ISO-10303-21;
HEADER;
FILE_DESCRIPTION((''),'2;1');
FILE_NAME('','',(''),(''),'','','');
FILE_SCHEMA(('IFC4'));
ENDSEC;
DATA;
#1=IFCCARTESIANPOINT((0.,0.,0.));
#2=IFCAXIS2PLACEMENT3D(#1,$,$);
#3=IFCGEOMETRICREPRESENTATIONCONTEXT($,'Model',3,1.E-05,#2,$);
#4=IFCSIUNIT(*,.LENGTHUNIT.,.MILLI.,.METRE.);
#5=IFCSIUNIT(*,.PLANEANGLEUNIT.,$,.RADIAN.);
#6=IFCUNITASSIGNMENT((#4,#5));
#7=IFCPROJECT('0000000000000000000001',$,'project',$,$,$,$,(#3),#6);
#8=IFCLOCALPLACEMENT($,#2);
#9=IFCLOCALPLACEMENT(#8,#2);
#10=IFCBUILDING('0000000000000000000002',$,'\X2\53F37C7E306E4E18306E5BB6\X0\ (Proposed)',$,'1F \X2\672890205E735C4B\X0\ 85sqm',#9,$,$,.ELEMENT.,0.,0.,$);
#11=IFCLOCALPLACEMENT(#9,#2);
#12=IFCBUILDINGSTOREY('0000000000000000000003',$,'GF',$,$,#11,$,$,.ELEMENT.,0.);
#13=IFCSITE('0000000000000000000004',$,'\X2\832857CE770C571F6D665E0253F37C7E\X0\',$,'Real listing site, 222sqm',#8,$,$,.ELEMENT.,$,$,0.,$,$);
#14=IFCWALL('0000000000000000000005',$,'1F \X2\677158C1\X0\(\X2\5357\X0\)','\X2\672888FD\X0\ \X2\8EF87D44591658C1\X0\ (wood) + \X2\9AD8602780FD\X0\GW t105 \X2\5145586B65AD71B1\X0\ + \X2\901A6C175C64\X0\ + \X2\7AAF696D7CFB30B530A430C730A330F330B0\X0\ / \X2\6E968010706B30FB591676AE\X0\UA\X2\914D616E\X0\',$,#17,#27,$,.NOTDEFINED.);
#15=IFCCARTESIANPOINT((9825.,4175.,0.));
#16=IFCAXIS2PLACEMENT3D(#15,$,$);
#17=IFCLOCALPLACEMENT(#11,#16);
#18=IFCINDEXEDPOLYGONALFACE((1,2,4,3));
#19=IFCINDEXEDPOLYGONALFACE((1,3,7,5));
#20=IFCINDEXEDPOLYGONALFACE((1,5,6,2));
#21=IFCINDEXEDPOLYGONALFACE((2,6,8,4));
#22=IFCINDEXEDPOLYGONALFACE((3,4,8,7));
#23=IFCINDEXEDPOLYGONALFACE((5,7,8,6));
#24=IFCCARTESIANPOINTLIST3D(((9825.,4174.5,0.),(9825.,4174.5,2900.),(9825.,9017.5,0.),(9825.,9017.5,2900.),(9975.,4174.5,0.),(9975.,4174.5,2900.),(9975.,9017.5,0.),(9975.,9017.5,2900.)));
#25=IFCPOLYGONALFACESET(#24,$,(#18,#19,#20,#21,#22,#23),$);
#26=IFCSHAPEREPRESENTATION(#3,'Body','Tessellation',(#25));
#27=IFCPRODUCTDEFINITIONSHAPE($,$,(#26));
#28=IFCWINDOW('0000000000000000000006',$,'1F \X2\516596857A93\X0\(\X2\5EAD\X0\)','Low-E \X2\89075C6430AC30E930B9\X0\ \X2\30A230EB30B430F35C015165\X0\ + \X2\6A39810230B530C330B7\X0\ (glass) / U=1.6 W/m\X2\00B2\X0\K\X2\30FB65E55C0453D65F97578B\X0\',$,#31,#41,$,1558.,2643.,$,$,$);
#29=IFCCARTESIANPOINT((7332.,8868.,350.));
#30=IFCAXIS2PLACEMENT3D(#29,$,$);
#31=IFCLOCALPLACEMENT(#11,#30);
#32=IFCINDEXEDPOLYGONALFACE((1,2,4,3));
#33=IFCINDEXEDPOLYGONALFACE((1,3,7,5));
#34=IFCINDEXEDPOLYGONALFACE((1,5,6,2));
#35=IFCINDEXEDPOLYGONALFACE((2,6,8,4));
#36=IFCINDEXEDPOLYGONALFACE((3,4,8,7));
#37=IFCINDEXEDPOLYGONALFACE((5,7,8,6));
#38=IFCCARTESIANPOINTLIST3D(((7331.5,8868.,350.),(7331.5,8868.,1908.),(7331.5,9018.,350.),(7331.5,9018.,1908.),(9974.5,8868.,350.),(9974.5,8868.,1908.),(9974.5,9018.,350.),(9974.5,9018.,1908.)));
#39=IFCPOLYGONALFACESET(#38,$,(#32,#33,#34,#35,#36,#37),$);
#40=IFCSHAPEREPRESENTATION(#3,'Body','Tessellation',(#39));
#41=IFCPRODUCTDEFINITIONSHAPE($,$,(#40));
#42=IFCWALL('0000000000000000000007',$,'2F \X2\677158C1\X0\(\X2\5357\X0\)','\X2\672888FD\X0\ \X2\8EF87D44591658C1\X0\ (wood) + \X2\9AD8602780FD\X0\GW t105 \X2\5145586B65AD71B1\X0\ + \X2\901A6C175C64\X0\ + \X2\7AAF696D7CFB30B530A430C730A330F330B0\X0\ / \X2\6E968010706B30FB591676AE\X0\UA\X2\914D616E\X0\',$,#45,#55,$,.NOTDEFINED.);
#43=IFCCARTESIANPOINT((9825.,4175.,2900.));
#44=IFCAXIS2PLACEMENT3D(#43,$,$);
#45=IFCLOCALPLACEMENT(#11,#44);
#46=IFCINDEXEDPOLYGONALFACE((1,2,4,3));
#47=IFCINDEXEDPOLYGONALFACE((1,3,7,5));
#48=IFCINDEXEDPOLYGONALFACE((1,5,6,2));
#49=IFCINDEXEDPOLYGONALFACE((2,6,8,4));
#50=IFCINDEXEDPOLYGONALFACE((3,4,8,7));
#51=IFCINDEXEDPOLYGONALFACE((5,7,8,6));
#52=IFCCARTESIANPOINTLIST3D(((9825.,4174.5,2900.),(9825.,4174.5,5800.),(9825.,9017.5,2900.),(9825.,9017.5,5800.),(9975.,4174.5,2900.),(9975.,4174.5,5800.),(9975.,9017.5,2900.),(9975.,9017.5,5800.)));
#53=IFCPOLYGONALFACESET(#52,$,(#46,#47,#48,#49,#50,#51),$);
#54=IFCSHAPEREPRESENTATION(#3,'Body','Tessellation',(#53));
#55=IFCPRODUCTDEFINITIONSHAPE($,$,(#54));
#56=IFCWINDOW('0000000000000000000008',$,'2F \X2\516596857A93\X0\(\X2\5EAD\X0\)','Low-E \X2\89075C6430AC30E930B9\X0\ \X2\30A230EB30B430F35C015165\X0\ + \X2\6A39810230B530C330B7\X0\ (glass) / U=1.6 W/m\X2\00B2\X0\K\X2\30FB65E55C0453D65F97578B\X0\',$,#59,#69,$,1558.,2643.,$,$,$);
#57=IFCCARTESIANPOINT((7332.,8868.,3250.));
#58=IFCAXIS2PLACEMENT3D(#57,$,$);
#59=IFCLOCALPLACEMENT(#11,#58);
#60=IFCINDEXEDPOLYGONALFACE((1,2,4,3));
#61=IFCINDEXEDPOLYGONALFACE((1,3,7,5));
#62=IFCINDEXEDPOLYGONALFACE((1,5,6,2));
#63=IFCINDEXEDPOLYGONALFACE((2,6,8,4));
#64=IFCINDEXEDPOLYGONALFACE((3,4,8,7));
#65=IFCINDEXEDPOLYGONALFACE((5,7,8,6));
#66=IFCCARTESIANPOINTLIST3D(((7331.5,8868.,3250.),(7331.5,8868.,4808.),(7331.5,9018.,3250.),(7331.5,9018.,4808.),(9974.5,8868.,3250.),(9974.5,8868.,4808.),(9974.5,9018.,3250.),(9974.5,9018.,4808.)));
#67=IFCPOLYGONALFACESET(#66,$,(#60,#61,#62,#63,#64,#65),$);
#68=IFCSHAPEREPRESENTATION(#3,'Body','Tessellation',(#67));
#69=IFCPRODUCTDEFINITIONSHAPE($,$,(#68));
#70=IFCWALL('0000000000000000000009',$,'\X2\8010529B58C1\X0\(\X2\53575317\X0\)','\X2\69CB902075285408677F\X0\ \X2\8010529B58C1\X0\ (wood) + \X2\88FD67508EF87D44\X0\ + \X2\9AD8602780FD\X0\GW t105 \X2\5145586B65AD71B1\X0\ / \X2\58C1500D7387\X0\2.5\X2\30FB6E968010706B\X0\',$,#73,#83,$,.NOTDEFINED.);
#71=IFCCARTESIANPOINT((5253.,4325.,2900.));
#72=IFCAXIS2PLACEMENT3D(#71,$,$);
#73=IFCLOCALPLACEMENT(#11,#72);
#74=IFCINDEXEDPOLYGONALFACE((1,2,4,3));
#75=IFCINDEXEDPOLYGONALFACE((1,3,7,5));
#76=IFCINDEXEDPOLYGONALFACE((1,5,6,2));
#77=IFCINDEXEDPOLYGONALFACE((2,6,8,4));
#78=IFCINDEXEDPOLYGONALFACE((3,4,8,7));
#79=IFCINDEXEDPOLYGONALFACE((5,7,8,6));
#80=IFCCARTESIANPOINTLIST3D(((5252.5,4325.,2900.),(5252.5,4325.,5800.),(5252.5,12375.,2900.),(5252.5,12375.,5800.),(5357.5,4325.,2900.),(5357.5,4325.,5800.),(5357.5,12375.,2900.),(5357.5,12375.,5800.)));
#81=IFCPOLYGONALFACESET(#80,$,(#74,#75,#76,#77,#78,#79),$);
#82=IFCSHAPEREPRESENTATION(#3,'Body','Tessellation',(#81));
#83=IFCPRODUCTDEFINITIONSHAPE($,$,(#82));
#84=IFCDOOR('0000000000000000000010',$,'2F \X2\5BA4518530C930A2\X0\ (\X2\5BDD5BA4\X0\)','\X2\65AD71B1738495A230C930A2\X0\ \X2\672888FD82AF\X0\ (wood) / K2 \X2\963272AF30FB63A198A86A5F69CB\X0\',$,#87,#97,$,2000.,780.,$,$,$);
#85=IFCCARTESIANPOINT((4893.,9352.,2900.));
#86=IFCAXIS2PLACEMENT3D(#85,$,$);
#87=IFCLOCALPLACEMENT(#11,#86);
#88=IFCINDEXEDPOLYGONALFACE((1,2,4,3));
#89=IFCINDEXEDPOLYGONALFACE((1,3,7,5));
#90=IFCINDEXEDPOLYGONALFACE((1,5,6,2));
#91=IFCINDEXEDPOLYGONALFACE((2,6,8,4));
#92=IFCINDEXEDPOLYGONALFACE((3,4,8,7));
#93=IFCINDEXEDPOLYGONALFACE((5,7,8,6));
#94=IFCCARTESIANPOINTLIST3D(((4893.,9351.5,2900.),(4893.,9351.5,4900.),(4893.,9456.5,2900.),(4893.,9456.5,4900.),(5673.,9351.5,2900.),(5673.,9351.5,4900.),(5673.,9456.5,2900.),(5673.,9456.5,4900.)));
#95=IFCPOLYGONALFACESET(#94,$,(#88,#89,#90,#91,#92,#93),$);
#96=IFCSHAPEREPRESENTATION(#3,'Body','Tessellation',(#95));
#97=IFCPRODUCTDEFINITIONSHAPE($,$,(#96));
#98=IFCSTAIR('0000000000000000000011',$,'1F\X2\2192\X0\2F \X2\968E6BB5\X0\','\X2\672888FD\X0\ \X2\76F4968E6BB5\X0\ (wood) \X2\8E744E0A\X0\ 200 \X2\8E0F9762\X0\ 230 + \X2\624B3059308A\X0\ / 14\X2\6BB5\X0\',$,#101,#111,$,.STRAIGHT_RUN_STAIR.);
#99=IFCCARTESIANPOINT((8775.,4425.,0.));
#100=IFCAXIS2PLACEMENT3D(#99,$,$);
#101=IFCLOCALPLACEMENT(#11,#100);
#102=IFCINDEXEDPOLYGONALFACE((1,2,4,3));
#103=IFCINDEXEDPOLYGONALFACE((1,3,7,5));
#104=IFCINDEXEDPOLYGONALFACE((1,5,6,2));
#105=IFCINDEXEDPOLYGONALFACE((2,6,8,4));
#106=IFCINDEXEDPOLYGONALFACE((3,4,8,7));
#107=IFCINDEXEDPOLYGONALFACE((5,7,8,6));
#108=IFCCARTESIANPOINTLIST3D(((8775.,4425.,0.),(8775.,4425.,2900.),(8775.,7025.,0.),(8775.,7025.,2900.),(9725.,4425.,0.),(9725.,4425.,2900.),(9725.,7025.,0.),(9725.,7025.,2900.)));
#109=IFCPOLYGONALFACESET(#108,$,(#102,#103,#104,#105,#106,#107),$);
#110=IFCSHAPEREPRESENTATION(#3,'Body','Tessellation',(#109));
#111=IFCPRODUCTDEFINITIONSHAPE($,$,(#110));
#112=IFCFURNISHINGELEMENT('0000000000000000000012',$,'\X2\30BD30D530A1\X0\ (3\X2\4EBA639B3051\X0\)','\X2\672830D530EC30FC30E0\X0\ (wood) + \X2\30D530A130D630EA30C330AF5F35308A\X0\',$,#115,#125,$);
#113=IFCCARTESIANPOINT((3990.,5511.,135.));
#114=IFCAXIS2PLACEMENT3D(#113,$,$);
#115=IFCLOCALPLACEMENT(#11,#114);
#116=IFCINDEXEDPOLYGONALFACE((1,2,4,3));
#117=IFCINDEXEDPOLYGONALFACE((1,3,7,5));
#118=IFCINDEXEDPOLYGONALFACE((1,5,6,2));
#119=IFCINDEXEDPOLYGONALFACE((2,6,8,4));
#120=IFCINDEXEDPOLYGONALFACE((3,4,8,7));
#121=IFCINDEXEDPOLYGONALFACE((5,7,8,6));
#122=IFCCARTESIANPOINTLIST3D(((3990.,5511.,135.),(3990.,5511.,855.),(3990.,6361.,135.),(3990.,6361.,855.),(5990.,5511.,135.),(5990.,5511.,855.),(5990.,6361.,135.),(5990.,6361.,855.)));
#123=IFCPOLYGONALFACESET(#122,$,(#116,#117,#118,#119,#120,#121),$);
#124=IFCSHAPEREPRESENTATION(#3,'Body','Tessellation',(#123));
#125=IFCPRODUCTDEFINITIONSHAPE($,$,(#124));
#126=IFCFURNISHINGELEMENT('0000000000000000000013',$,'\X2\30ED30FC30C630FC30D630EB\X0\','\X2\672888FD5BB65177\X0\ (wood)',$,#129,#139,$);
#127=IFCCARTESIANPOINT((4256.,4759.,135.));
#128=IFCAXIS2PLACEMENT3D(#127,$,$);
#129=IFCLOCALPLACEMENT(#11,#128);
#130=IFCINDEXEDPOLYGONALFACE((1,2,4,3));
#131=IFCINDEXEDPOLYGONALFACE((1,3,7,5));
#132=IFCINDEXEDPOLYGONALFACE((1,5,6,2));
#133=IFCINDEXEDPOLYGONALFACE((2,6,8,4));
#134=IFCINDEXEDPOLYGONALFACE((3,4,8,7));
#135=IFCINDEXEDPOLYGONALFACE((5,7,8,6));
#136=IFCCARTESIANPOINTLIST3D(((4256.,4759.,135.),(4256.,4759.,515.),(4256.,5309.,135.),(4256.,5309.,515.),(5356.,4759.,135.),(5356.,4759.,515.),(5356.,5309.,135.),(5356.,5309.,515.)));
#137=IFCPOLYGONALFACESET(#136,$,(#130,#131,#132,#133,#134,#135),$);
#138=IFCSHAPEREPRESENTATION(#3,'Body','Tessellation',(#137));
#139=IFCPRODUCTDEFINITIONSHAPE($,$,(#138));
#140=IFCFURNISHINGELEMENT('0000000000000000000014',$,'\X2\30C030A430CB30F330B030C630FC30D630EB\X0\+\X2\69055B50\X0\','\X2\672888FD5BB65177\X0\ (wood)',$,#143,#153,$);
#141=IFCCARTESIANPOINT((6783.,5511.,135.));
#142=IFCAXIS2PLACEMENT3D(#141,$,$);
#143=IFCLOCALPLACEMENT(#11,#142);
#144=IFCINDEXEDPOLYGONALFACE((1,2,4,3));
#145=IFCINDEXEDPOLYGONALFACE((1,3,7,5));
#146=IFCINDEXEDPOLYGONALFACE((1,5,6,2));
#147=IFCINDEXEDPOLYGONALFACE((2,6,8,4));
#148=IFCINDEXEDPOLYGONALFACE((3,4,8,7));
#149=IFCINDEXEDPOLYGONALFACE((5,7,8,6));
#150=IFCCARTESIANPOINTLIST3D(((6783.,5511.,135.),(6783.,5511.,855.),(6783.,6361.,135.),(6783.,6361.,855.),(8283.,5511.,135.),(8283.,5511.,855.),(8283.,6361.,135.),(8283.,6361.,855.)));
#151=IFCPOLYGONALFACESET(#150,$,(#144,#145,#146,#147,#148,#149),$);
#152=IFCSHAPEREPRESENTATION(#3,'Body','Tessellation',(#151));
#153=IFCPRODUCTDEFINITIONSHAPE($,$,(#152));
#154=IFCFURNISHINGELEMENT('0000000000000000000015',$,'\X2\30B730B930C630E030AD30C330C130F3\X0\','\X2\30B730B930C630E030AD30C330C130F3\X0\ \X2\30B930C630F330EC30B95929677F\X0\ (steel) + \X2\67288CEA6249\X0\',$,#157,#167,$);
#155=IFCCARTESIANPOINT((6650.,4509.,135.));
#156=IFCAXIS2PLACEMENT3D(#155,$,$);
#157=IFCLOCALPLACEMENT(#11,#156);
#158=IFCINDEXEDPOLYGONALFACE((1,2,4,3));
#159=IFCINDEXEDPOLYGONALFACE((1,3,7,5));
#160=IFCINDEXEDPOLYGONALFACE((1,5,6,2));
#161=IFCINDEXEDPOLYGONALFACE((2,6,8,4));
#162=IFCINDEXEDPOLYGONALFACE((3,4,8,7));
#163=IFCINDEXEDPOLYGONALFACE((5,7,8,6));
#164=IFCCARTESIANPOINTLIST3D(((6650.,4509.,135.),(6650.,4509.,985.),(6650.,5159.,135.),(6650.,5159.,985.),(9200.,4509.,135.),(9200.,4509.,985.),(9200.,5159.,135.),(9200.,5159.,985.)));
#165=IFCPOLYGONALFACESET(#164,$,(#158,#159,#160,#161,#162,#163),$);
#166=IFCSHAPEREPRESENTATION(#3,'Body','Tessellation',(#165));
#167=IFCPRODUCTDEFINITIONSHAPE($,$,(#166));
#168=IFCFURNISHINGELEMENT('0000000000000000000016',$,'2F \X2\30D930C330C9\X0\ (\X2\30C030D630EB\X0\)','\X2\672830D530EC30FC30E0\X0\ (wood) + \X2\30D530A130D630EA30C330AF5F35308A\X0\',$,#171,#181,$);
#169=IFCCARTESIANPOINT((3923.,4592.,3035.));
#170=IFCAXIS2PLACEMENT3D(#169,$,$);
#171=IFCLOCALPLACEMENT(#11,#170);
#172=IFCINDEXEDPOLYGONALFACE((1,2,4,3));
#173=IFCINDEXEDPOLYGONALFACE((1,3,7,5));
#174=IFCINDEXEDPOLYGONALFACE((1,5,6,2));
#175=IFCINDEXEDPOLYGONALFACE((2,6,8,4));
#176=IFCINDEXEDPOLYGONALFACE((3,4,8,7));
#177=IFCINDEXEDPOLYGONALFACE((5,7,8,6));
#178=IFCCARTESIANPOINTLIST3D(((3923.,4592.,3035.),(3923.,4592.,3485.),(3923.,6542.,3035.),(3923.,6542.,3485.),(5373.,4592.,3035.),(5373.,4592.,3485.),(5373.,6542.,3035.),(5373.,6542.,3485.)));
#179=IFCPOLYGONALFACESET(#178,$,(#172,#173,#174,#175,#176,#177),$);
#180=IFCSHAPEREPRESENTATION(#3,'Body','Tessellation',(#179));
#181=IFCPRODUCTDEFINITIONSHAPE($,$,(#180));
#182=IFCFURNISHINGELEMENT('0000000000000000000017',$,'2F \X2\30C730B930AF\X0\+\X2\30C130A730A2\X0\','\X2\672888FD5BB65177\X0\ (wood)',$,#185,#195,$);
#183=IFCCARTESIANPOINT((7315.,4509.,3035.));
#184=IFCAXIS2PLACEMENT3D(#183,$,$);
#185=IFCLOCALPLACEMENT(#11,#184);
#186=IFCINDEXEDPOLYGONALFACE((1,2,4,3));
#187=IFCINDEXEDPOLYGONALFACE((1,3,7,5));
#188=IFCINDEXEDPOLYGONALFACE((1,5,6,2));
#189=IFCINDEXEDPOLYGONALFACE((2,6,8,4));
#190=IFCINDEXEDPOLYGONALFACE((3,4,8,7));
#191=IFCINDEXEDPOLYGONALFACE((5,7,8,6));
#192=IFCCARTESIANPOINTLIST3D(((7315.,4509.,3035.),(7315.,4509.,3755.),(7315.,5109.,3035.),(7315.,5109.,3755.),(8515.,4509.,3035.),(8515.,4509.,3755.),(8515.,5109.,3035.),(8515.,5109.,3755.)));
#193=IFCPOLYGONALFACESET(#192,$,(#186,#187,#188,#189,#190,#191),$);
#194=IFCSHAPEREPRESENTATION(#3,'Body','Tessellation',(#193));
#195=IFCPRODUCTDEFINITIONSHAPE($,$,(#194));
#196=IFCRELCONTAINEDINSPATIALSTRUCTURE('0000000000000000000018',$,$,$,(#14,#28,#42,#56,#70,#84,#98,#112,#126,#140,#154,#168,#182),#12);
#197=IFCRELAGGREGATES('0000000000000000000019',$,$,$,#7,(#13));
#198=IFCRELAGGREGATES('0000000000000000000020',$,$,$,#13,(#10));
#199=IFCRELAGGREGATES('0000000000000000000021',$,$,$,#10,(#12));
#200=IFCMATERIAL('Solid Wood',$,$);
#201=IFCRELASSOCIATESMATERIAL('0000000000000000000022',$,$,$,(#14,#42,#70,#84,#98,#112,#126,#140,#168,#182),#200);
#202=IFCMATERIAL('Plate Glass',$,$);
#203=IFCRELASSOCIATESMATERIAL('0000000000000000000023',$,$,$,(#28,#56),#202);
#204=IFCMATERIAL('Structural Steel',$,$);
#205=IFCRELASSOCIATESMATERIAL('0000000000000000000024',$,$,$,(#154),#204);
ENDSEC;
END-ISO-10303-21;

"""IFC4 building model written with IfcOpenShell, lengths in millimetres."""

from ifc_helpers import new_model, si_unit, frame, frame_2d, origin, place, context, project, spatial, rectangle, extrude, material, element, fill, save


model = new_model("IFC4")

# Units and contexts
model_context = context("Model", 3, precision=1e-05, world=origin())
ifc_project = project(units=[si_unit("LENGTHUNIT", "METRE", prefix="MILLI"), si_unit("PLANEANGLEUNIT", "RADIAN")], contexts=[model_context])

# Site, building, storey
site_placement = place(None, origin())
site = spatial("IfcSite", under=ifc_project, at=site_placement, Name="茨城県土浦市右籾", ObjectType="Real listing site, 222sqm", CompositionType="ELEMENT", RefElevation=0.0)
building_placement = place(site_placement, origin())
building = spatial("IfcBuilding", under=site, at=building_placement, Name="右籾の丘の家 (Proposed)", ObjectType="1F 木造平屋 85sqm", CompositionType="ELEMENT", ElevationOfRefHeight=0.0, ElevationOfTerrain=0.0)
storey_placement = place(building_placement, origin())
storey = spatial("IfcBuildingStorey", under=building, at=storey_placement, Name="GF", CompositionType="ELEMENT", Elevation=0.0)

# Wall, opening, window
ifc_material_1 = material(Name="Solid Wood")
wall_1_placement = place(storey_placement, frame((9825.0, 4175.0, 0.0)))
wall_1 = element("IfcWall", 1, at=wall_1_placement, inside=storey, material=ifc_material_1, Name="1F 東壁(南)", Description="木製 軸組外壁 (wood) + 高性能GW t105 充填断熱 + 通気層 + 窯業系サイディング / 準耐火・外皮UA配慮", PredefinedType="NOTDEFINED", context=model_context, shape_type="SweptSolid", body=[
    extrude(rectangle(XDim=150.0, YDim=4843.0, at=frame_2d((75.0, 2421.0))), frame((9825.0, 4175.0, 0.0)), (0.0, 0.0, 1.0), 2900.0),
])
opening_1_placement = place(storey_placement, frame((7332.0, 8868.0, 350.0)))
opening_1 = element("IfcOpeningElement", 2, at=opening_1_placement, cuts=wall_1, PredefinedType="NOTDEFINED", context=model_context, shape_type="SweptSolid", body=[
    extrude(rectangle(XDim=2643.0, YDim=150.0, at=frame_2d((1321.0, 75.0))), frame((7332.0, 8868.0, 350.0)), (0.0, 0.0, 1.0), 1558.0),
])
ifc_material_2 = material(Name="Plate Glass")
window_1_placement = place(storey_placement, frame((7332.0, 8868.0, 350.0)))
window_1 = element("IfcWindow", 3, at=window_1_placement, inside=storey, material=ifc_material_2, Name="1F 入隅窓(庭)", Description="Low-E 複層ガラス アルゴン封入 + 樹脂サッシ (glass) / U=1.6 W/m²K・日射取得型", OverallHeight=1558.0, OverallWidth=2643.0, context=model_context, shape_type="SweptSolid", body=[
    extrude(rectangle(XDim=2643.0, YDim=150.0, at=frame_2d((1321.0, 75.0))), frame((7332.0, 8868.0, 350.0)), (0.0, 0.0, 1.0), 1558.0),
])
fill(opening_1, window_1)

# Wall, opening, window
wall_2_placement = place(storey_placement, frame((9825.0, 4175.0, 2900.0)))
wall_2 = element("IfcWall", 4, at=wall_2_placement, inside=storey, material=ifc_material_1, Name="2F 東壁(南)", Description="木製 軸組外壁 (wood) + 高性能GW t105 充填断熱 + 通気層 + 窯業系サイディング / 準耐火・外皮UA配慮", PredefinedType="NOTDEFINED", context=model_context, shape_type="SweptSolid", body=[
    extrude(rectangle(XDim=150.0, YDim=4843.0, at=frame_2d((75.0, 2421.0))), frame((9825.0, 4175.0, 2900.0)), (0.0, 0.0, 1.0), 2900.0),
])
opening_2_placement = place(storey_placement, frame((7332.0, 8868.0, 3250.0)))
opening_2 = element("IfcOpeningElement", 5, at=opening_2_placement, cuts=wall_2, PredefinedType="NOTDEFINED", context=model_context, shape_type="SweptSolid", body=[
    extrude(rectangle(XDim=2643.0, YDim=150.0, at=frame_2d((1321.0, 75.0))), frame((7332.0, 8868.0, 3250.0)), (0.0, 0.0, 1.0), 1558.0),
])
window_2_placement = place(storey_placement, frame((7332.0, 8868.0, 3250.0)))
window_2 = element("IfcWindow", 6, at=window_2_placement, inside=storey, material=ifc_material_2, Name="2F 入隅窓(庭)", Description="Low-E 複層ガラス アルゴン封入 + 樹脂サッシ (glass) / U=1.6 W/m²K・日射取得型", OverallHeight=1558.0, OverallWidth=2643.0, context=model_context, shape_type="SweptSolid", body=[
    extrude(rectangle(XDim=2643.0, YDim=150.0, at=frame_2d((1321.0, 75.0))), frame((7332.0, 8868.0, 3250.0)), (0.0, 0.0, 1.0), 1558.0),
])
fill(opening_2, window_2)

# Wall, opening, door
wall_3_placement = place(storey_placement, frame((5253.0, 4325.0, 2900.0)))
wall_3 = element("IfcWall", 7, at=wall_3_placement, inside=storey, material=ifc_material_1, Name="耐力壁(南北)", Description="構造用合板 耐力壁 (wood) + 製材軸組 + 高性能GW t105 充填断熱 / 壁倍率2.5・準耐火", PredefinedType="NOTDEFINED", context=model_context, shape_type="SweptSolid", body=[
    extrude(rectangle(XDim=105.0, YDim=8050.0, at=frame_2d((52.0, 4025.0))), frame((5253.0, 4325.0, 2900.0)), (0.0, 0.0, 1.0), 2900.0),
])
opening_3_placement = place(storey_placement, frame((4893.0, 9352.0, 2900.0)))
opening_3 = element("IfcOpeningElement", 8, at=opening_3_placement, cuts=wall_3, PredefinedType="NOTDEFINED", context=model_context, shape_type="SweptSolid", body=[
    extrude(rectangle(XDim=780.0, YDim=105.0, at=frame_2d((390.0, 52.0))), frame((4893.0, 9352.0, 2900.0)), (0.0, 0.0, 1.0), 2000.0),
])
door_1_placement = place(storey_placement, frame((4893.0, 9352.0, 2900.0)))
door_1 = element("IfcDoor", 9, at=door_1_placement, inside=storey, material=ifc_material_1, Name="2F 室内ドア (寝室)", Description="断熱玄関ドア 木製芯 (wood) / K2 防犯・採風機構", OverallHeight=2000.0, OverallWidth=780.0, context=model_context, shape_type="SweptSolid", body=[
    extrude(rectangle(XDim=780.0, YDim=105.0, at=frame_2d((390.0, 52.0))), frame((4893.0, 9352.0, 2900.0)), (0.0, 0.0, 1.0), 2000.0),
])
fill(opening_3, door_1)

# Stair
stair_placement = place(storey_placement, frame((8775.0, 4425.0, 0.0)))
element("IfcStair", 10, at=stair_placement, inside=storey, material=ifc_material_1, Name="1F→2F 階段", Description="木製 直階段 (wood) 蹴上 200 踏面 230 + 手すり / 14段", PredefinedType="STRAIGHT_RUN_STAIR", context=model_context, shape_type="SweptSolid", body=[
    extrude(rectangle(XDim=950.0, YDim=2600.0, at=frame_2d((475.0, 1300.0))), frame((8775.0, 4425.0, 0.0)), (0.0, 0.0, 1.0), 2900.0),
])

# Furnishing elements
furnishing_1_placement = place(storey_placement, frame((3990.0, 5511.0, 135.0)))
element("IfcFurnishingElement", 11, at=furnishing_1_placement, inside=storey, material=ifc_material_1, Name="ソファ (3人掛け)", Description="木フレーム (wood) + ファブリック張り", context=model_context, shape_type="SweptSolid", body=[
    extrude(rectangle(XDim=2000.0, YDim=850.0, at=frame_2d((1000.0, 425.0))), frame((3990.0, 5511.0, 135.0)), (0.0, 0.0, 1.0), 720.0),
])
furnishing_2_placement = place(storey_placement, frame((4256.0, 4759.0, 135.0)))
element("IfcFurnishingElement", 12, at=furnishing_2_placement, inside=storey, material=ifc_material_1, Name="ローテーブル", Description="木製家具 (wood)", context=model_context, shape_type="SweptSolid", body=[
    extrude(rectangle(XDim=1100.0, YDim=550.0, at=frame_2d((550.0, 275.0))), frame((4256.0, 4759.0, 135.0)), (0.0, 0.0, 1.0), 380.0),
])
furnishing_3_placement = place(storey_placement, frame((6783.0, 5511.0, 135.0)))
element("IfcFurnishingElement", 13, at=furnishing_3_placement, inside=storey, material=ifc_material_1, Name="ダイニングテーブル+椅子", Description="木製家具 (wood)", context=model_context, shape_type="SweptSolid", body=[
    extrude(rectangle(XDim=1500.0, YDim=850.0, at=frame_2d((750.0, 425.0))), frame((6783.0, 5511.0, 135.0)), (0.0, 0.0, 1.0), 720.0),
])
ifc_material_3 = material(Name="Structural Steel")
furnishing_4_placement = place(storey_placement, frame((6650.0, 4509.0, 135.0)))
element("IfcFurnishingElement", 14, at=furnishing_4_placement, inside=storey, material=ifc_material_3, Name="システムキッチン", Description="システムキッチン ステンレス天板 (steel) + 木質扉", context=model_context, shape_type="SweptSolid", body=[
    extrude(rectangle(XDim=2550.0, YDim=650.0, at=frame_2d((1275.0, 325.0))), frame((6650.0, 4509.0, 135.0)), (0.0, 0.0, 1.0), 850.0),
])
furnishing_5_placement = place(storey_placement, frame((3923.0, 4592.0, 3035.0)))
element("IfcFurnishingElement", 15, at=furnishing_5_placement, inside=storey, material=ifc_material_1, Name="2F ベッド (ダブル)", Description="木フレーム (wood) + ファブリック張り", context=model_context, shape_type="SweptSolid", body=[
    extrude(rectangle(XDim=1450.0, YDim=1950.0, at=frame_2d((725.0, 975.0))), frame((3923.0, 4592.0, 3035.0)), (0.0, 0.0, 1.0), 450.0),
])
furnishing_6_placement = place(storey_placement, frame((7315.0, 4509.0, 3035.0)))
element("IfcFurnishingElement", 16, at=furnishing_6_placement, inside=storey, material=ifc_material_1, Name="2F デスク+チェア", Description="木製家具 (wood)", context=model_context, shape_type="SweptSolid", body=[
    extrude(rectangle(XDim=1200.0, YDim=600.0, at=frame_2d((600.0, 300.0))), frame((7315.0, 4509.0, 3035.0)), (0.0, 0.0, 1.0), 720.0),
])

save(model, "model.ifc")
